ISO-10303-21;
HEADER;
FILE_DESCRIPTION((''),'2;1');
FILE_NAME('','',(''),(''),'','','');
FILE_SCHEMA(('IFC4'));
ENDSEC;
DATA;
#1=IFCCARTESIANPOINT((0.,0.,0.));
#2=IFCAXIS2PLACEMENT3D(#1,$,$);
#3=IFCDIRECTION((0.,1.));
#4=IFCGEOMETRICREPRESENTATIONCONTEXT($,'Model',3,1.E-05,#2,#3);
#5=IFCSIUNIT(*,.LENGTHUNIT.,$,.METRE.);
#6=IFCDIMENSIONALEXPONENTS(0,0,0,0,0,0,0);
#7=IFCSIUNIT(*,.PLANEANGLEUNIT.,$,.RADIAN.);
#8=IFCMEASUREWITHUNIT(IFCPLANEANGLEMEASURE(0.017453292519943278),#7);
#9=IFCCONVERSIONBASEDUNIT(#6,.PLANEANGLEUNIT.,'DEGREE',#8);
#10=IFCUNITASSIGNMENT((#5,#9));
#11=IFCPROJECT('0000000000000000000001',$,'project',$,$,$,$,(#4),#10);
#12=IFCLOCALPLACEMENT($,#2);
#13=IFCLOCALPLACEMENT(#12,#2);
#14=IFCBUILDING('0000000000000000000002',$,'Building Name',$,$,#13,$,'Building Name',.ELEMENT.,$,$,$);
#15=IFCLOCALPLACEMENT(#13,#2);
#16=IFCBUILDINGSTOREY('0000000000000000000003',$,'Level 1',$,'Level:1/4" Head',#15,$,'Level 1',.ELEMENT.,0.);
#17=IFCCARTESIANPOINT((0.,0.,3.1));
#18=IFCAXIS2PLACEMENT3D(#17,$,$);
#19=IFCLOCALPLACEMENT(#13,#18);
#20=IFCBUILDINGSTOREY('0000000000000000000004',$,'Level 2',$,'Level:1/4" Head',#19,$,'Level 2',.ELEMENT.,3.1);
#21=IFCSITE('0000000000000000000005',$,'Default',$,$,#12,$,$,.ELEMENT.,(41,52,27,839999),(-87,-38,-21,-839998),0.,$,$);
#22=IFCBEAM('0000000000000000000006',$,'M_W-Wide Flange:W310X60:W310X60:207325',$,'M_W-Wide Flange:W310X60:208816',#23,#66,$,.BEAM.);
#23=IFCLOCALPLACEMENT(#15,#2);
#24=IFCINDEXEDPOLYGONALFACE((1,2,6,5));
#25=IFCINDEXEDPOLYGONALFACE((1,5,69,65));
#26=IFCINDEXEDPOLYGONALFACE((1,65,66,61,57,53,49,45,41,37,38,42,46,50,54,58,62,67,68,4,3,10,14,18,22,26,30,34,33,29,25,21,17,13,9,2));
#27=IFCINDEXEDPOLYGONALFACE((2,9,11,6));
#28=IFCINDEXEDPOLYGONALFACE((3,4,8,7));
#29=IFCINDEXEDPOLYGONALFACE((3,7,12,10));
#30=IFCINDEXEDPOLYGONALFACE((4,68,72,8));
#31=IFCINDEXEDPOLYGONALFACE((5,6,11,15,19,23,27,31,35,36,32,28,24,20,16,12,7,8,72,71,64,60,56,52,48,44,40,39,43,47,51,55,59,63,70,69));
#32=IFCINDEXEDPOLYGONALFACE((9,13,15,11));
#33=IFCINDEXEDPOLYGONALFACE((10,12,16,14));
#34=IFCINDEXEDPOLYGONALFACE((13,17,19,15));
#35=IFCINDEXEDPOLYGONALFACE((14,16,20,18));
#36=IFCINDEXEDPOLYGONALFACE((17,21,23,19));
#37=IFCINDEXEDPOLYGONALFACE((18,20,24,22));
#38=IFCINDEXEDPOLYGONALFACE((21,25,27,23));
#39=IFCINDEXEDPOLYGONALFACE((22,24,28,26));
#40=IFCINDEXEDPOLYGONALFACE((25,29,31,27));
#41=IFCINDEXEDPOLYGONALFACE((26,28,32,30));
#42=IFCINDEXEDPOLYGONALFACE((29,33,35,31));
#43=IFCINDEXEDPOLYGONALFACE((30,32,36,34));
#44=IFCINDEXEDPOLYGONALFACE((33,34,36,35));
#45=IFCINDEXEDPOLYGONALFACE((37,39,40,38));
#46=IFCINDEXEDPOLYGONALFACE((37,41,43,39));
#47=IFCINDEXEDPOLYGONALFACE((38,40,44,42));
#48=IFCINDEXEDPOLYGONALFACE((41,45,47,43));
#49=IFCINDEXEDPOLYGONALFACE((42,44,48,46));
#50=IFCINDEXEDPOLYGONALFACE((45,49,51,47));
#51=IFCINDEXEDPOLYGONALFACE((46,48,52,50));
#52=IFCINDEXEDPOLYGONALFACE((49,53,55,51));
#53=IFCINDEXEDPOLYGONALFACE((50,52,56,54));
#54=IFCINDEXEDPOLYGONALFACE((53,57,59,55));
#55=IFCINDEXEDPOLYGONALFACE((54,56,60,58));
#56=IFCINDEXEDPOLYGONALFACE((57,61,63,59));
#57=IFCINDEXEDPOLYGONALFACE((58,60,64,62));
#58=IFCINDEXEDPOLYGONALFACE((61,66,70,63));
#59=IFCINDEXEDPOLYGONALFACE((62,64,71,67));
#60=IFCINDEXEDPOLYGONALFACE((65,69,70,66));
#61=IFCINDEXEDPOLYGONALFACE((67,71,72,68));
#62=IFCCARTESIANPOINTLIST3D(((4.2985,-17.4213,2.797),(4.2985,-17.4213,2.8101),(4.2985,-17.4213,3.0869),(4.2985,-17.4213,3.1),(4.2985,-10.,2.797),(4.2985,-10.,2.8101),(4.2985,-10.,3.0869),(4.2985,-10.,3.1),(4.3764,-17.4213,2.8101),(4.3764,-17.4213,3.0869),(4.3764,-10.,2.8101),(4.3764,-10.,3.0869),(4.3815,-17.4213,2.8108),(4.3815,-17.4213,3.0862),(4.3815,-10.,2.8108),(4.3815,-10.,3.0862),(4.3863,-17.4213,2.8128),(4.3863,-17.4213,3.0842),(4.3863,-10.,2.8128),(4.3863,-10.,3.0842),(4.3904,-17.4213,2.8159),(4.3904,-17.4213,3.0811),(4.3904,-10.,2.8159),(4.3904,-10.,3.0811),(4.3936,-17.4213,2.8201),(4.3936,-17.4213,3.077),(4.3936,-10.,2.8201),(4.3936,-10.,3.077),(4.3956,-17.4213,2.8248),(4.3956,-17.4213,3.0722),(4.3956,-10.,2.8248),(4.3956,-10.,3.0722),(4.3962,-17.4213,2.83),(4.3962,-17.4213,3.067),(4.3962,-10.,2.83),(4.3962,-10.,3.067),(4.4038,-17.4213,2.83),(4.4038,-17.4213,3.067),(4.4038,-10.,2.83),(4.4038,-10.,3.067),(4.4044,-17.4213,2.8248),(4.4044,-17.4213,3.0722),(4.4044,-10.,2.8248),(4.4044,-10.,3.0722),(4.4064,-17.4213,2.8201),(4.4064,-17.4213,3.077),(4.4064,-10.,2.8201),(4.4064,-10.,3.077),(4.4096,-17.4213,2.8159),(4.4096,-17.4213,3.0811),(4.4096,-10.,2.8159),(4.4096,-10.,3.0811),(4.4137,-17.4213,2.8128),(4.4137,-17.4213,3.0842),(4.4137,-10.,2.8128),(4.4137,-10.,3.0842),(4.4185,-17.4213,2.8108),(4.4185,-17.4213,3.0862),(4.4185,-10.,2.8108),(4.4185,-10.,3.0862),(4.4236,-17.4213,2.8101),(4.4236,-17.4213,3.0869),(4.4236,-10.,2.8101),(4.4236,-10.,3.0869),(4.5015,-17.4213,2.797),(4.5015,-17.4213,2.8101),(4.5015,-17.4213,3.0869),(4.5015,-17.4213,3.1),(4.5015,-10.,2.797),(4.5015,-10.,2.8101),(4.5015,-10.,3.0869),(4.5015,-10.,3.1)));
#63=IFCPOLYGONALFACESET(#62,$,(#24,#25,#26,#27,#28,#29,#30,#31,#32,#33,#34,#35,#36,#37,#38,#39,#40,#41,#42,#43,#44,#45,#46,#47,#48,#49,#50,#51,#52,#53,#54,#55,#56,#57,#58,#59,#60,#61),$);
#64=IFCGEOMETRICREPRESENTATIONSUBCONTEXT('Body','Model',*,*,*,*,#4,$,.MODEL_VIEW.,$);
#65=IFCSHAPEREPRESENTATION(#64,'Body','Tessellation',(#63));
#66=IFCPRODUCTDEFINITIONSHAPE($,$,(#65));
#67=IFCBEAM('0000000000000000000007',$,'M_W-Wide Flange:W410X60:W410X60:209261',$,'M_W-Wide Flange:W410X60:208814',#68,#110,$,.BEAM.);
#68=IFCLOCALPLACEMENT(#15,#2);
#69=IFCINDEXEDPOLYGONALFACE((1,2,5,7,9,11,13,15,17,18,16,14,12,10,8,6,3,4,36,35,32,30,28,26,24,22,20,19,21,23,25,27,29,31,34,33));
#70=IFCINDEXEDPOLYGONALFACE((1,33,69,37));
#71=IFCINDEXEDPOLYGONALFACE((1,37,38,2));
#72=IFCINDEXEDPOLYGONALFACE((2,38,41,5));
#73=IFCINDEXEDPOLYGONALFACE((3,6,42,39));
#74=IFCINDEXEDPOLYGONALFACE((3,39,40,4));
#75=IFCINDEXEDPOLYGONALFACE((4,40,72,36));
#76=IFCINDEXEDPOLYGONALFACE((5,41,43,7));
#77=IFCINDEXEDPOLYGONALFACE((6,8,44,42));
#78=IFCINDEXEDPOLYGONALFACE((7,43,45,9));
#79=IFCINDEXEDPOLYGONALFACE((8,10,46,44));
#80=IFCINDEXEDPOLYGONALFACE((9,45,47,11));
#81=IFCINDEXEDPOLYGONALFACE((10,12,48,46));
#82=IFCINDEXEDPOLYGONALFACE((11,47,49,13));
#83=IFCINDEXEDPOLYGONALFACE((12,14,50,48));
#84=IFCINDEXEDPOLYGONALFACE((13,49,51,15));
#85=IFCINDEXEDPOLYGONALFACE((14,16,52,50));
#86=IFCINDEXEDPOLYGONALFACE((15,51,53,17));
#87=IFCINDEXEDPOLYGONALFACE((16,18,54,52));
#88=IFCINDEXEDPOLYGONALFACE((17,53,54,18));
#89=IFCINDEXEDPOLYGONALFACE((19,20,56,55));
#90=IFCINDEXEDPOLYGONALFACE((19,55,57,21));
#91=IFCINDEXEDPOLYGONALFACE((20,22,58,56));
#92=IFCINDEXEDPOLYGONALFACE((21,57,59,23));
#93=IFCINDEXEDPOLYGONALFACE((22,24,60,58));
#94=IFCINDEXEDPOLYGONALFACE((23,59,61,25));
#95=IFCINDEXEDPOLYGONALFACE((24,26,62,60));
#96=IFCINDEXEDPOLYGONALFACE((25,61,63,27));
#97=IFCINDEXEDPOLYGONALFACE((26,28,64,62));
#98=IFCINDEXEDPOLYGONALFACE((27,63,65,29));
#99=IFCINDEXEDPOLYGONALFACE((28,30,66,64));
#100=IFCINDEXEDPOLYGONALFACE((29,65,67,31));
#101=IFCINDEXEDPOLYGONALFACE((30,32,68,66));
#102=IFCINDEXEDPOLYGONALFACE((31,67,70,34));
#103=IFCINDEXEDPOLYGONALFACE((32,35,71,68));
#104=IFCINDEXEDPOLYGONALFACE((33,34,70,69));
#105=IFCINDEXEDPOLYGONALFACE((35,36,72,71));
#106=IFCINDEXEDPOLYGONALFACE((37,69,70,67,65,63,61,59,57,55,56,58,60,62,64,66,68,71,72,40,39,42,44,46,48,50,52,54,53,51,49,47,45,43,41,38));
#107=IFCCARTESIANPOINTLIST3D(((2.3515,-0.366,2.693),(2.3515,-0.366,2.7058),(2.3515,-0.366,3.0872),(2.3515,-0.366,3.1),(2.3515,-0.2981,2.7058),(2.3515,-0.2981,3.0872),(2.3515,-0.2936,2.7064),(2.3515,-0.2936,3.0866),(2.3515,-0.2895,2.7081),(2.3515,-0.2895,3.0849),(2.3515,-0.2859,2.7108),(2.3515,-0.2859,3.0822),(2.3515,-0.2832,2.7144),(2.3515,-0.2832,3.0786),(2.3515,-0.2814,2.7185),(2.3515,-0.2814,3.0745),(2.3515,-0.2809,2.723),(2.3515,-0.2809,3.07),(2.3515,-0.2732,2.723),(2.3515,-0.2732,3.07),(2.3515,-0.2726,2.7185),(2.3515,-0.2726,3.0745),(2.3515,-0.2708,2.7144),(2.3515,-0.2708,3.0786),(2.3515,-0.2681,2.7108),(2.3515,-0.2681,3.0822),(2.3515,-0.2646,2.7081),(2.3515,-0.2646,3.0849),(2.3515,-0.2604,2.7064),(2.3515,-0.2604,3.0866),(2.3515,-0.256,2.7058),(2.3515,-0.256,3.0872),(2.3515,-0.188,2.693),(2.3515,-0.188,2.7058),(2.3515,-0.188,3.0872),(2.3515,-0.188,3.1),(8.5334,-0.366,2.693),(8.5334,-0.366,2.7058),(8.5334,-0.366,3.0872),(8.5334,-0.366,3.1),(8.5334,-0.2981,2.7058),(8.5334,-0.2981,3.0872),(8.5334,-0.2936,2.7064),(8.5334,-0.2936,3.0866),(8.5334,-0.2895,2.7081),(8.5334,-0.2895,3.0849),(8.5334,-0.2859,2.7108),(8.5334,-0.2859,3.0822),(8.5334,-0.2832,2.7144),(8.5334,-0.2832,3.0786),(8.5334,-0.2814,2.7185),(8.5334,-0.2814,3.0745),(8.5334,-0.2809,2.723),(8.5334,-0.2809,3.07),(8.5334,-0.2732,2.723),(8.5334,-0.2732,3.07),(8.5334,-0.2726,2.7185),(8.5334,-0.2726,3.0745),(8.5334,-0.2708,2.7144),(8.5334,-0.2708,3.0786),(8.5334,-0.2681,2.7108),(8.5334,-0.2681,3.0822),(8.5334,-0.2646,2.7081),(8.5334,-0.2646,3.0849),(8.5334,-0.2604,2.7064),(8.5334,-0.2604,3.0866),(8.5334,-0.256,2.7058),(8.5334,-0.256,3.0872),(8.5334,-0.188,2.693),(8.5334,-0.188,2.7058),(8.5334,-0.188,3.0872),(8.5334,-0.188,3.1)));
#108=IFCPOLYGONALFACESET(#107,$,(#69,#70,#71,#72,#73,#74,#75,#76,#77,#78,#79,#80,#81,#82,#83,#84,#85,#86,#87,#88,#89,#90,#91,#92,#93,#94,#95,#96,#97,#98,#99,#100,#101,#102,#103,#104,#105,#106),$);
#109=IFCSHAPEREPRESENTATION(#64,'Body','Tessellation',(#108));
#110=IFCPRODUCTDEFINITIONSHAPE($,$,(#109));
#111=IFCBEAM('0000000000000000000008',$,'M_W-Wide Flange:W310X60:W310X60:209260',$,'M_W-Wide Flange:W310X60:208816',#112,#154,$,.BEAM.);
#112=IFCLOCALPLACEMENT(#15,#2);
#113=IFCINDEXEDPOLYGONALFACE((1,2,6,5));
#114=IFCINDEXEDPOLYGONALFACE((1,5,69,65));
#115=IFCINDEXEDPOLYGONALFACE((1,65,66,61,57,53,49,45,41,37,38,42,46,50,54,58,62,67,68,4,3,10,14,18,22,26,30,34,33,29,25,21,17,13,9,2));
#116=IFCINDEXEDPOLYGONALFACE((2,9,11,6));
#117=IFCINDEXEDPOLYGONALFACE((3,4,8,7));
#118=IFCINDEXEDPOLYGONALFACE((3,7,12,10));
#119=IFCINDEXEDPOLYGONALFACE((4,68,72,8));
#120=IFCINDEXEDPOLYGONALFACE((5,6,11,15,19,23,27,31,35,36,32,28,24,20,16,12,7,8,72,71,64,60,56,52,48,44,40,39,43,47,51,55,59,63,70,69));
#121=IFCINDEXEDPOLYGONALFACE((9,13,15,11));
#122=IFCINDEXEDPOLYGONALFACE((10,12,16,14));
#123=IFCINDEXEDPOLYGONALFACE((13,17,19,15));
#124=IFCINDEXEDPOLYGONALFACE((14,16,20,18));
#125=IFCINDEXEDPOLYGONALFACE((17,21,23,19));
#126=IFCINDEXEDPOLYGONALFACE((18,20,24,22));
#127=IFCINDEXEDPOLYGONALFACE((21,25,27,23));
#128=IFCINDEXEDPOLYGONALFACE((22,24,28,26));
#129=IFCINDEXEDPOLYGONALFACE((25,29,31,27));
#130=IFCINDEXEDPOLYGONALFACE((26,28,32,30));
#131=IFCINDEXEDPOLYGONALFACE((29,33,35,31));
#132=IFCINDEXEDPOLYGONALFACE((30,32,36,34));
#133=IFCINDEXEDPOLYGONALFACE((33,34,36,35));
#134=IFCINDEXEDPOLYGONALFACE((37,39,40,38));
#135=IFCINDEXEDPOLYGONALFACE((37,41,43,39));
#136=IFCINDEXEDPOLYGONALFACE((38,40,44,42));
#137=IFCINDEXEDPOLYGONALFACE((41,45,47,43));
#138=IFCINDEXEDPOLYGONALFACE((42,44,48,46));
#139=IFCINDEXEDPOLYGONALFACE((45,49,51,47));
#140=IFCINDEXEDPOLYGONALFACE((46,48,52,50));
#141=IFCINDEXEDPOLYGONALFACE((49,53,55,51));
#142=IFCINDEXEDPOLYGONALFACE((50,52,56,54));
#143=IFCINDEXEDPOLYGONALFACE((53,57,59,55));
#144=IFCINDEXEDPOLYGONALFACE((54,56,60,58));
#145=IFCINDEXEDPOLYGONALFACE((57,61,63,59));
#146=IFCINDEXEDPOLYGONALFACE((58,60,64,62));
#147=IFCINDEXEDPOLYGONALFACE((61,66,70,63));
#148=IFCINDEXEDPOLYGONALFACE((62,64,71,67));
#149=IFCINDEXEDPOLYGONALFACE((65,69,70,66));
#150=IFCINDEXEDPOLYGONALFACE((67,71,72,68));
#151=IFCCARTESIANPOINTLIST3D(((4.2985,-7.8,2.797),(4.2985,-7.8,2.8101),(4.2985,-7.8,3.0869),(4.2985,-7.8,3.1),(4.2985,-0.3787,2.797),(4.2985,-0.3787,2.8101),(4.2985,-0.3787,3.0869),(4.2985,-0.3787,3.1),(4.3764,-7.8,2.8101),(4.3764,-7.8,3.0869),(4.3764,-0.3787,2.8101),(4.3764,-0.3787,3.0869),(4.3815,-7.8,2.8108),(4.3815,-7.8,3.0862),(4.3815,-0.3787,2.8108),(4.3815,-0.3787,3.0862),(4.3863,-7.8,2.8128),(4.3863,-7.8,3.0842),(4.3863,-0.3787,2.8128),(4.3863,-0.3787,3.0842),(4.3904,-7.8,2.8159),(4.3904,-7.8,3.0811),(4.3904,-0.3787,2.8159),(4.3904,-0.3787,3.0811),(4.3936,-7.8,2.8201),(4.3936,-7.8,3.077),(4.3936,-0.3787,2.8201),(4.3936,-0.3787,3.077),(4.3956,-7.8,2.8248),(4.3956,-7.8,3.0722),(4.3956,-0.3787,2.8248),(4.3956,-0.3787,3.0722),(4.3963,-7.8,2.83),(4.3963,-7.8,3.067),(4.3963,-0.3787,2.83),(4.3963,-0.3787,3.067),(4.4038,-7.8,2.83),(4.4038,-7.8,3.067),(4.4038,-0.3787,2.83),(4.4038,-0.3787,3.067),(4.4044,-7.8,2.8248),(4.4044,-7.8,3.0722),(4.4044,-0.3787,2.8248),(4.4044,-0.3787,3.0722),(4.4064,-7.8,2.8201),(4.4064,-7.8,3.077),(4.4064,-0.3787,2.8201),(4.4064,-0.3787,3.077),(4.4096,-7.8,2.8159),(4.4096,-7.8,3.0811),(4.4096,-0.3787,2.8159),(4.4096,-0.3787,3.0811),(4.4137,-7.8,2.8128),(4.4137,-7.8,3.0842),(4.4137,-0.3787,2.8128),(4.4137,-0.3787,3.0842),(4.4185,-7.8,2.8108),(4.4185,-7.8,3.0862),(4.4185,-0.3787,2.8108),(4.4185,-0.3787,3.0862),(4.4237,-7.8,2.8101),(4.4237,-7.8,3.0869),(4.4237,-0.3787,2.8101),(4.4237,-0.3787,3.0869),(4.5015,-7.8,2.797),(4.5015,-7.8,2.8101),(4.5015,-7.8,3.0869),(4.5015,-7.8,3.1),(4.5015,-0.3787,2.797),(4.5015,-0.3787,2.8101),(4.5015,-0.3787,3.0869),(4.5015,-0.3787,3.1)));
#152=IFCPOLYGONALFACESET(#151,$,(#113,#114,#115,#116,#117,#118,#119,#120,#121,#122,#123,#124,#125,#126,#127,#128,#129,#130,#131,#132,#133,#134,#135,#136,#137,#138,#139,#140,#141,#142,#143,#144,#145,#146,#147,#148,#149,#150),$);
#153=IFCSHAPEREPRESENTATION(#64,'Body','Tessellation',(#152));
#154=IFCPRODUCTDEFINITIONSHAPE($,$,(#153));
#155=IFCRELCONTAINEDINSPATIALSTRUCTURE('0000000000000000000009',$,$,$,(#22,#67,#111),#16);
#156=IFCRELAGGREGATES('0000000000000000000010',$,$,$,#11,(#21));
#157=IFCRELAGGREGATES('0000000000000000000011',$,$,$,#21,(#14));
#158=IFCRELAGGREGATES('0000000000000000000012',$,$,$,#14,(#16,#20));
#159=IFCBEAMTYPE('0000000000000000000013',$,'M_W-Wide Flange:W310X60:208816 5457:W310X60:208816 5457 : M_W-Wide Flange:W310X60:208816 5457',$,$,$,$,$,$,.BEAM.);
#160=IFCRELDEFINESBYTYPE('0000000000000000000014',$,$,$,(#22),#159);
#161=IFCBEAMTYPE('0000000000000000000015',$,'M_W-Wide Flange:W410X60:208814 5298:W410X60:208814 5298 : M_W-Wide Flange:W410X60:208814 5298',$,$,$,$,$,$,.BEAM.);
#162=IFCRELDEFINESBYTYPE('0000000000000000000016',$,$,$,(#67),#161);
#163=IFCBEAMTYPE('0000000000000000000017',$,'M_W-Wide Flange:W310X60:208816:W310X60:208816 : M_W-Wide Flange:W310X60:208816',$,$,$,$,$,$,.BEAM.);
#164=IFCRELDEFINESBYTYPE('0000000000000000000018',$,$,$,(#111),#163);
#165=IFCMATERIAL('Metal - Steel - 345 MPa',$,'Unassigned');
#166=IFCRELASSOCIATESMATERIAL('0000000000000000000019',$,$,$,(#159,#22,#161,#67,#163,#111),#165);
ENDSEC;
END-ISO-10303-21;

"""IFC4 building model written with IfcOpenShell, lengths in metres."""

from ifc_helpers import new_model, entity, si_unit, converted_unit, direction, frame, origin, place, context, subcontext, project, spatial, line, arc, indexed_curve, outline, extrude, source, transform, mapped, material, type_object, type_shapes, element, save


model = new_model("IFC4")

# Units and contexts
model_context = context("Model", 3, precision=1e-05, world=origin(), true_north=direction((0.0, 1.0)))
body_context = subcontext(model_context, "Body", "Model", "MODEL_VIEW")
ifc_project = project(units=[si_unit("LENGTHUNIT", "METRE"), converted_unit("PLANEANGLEUNIT", "DEGREE", entity("IfcPlaneAngleMeasure", 0.017453292519943278), si_unit("PLANEANGLEUNIT", "RADIAN"), dimensions=[0, 0, 0, 0, 0, 0, 0])], contexts=[model_context])

# Site, building, storey
site_placement = place(None, origin())
site = spatial("IfcSite", under=ifc_project, at=site_placement, Name="Default", CompositionType="ELEMENT", RefLatitude=(41, 52, 27, 839999), RefLongitude=(-87, -38, -21, -839998), RefElevation=0.0)
building_placement = place(site_placement, origin())
building = spatial("IfcBuilding", under=site, at=building_placement, Name="Building Name", LongName="Building Name", CompositionType="ELEMENT")
storey_1_placement = place(building_placement, origin())
storey_1 = spatial("IfcBuildingStorey", under=building, at=storey_1_placement, Name="Level 1", ObjectType="Level:1/4\" Head", LongName="Level 1", CompositionType="ELEMENT", Elevation=0.0)

# Beams
ifc_material_1 = material(Name="Metal - Steel - 345 MPa", Category="Unassigned")
beam_type_1 = type_object("IfcBeamType", Name="M_W-Wide Flange:W310X60:208816 5457:W310X60:208816 5457 : M_W-Wide Flange:W310X60:208816 5457", PredefinedType="BEAM", material=ifc_material_1)
shared_shape_1 = source(origin(), body_context, "Body", "SweptSolid", [
    extrude(outline(indexed_curve([(-0.1515, -0.1015), (-0.1384, -0.1015), (-0.1384, -0.0237), (-0.1326, -0.0096), (-0.1185, -0.0038), (0.1185, -0.0038), (0.1326, -0.0096), (0.1384, -0.0237), (0.1384, -0.1015), (0.1515, -0.1015), (0.1515, 0.1015), (0.1384, 0.1015), (0.1384, 0.0236), (0.1326, 0.0096), (0.1185, 0.0038), (-0.1185, 0.0038), (-0.1326, 0.0096), (-0.1384, 0.0236), (-0.1384, 0.1015), (-0.1515, 0.1015)], segments=[line(1, 2, 3), arc(3, 4, 5), line(5, 6), arc(6, 7, 8), line(8, 9, 10, 11, 12, 13), arc(13, 14, 15), line(15, 16), arc(16, 17, 18), line(18, 19, 20, 1)], self_intersect=False)), frame((0.0, 0.0, -0.1515), z_axis=(0.0, 1.0, 0.0), x_axis=(0.0, 0.0, 1.0)), (0.0, 0.0, 1.0), 7.4213),
])
type_shapes(beam_type_1, [shared_shape_1])
beam_1_placement = place(storey_1_placement, frame((4.4, -10.0, 3.1), z_axis=(0.0, 0.0, 1.0), x_axis=(-1.0, 0.0, 0.0)))
element("IfcBeam", 1, at=beam_1_placement, inside=storey_1, type_object=beam_type_1, material=ifc_material_1, Name="M_W-Wide Flange:W310X60:W310X60:207325", ObjectType="M_W-Wide Flange:W310X60:208816", PredefinedType="BEAM", context=body_context, shape_type="MappedRepresentation", body=[
    mapped(shared_shape_1, transform((0.0, 0.0, 0.0), scale=1.0)),
])
beam_type_2 = type_object("IfcBeamType", Name="M_W-Wide Flange:W410X60:208814 5298:W410X60:208814 5298 : M_W-Wide Flange:W410X60:208814 5298", PredefinedType="BEAM", material=ifc_material_1)
shared_shape_2 = source(origin(), body_context, "Body", "SweptSolid", [
    extrude(outline(indexed_curve([(-0.2035, -0.089), (-0.1907, -0.089), (-0.1907, -0.0211), (-0.1857, -0.0089), (-0.1735, -0.0039), (0.1735, -0.0039), (0.1857, -0.0089), (0.1907, -0.0211), (0.1907, -0.089), (0.2035, -0.089), (0.2035, 0.089), (0.1907, 0.089), (0.1907, 0.0211), (0.1857, 0.0089), (0.1735, 0.0038), (-0.1735, 0.0038), (-0.1857, 0.0089), (-0.1907, 0.021), (-0.1907, 0.089), (-0.2035, 0.089)], segments=[line(1, 2, 3), arc(3, 4, 5), line(5, 6), arc(6, 7, 8), line(8, 9, 10, 11, 12, 13), arc(13, 14, 15), line(15, 16), arc(16, 17, 18), line(18, 19, 20, 1)], self_intersect=False)), frame((0.0, 0.0581, -0.2035), z_axis=(0.0, 1.0, 0.0), x_axis=(0.0, 0.0, 1.0)), (0.0, 0.0, 1.0), 6.1819),
])
type_shapes(beam_type_2, [shared_shape_2])
beam_2_placement = place(storey_1_placement, frame((8.5915, -0.277, 3.1), z_axis=(0.0, 0.0, 1.0), x_axis=(0.0, 1.0, 0.0)))
element("IfcBeam", 2, at=beam_2_placement, inside=storey_1, type_object=beam_type_2, material=ifc_material_1, Name="M_W-Wide Flange:W410X60:W410X60:209261", ObjectType="M_W-Wide Flange:W410X60:208814", PredefinedType="BEAM", context=body_context, shape_type="MappedRepresentation", body=[
    mapped(shared_shape_2, transform((0.0, 0.0, 0.0), scale=1.0)),
])
beam_type_3 = type_object("IfcBeamType", Name="M_W-Wide Flange:W310X60:208816:W310X60:208816 : M_W-Wide Flange:W310X60:208816", PredefinedType="BEAM", material=ifc_material_1)
shared_shape_3 = source(origin(), body_context, "Body", "SweptSolid", [
    extrude(outline(indexed_curve([(-0.0237, -0.1384), (-0.1015, -0.1384), (-0.1015, -0.1515), (0.1015, -0.1515), (0.1015, -0.1384), (0.0236, -0.1384), (0.0096, -0.1326), (0.0038, -0.1185), (0.0037, 0.1185), (0.0096, 0.1326), (0.0236, 0.1384), (0.1015, 0.1384), (0.1015, 0.1515), (-0.1015, 0.1515), (-0.1015, 0.1384), (-0.0236, 0.1384), (-0.0096, 0.1326), (-0.0038, 0.1185), (-0.0038, -0.1185), (-0.0096, -0.1326)], segments=[line(1, 2, 3, 4, 5, 6), arc(6, 7, 8), line(8, 9), arc(9, 10, 11), line(11, 12, 13, 14, 15, 16), arc(16, 17, 18), line(18, 19), arc(19, 20, 1)], self_intersect=False)), frame((0.0, 0.0, -0.1515), z_axis=(0.0, -1.0, 0.0), x_axis=(1.0, 0.0, 0.0)), (0.0, 0.0, -1.0), 7.4213),
])
type_shapes(beam_type_3, [shared_shape_3])
beam_3_placement = place(storey_1_placement, frame((4.4, -7.8, 3.1)))
element("IfcBeam", 3, at=beam_3_placement, inside=storey_1, type_object=beam_type_3, material=ifc_material_1, Name="M_W-Wide Flange:W310X60:W310X60:209260", ObjectType="M_W-Wide Flange:W310X60:208816", PredefinedType="BEAM", context=body_context, shape_type="MappedRepresentation", body=[
    mapped(shared_shape_3, transform((0.0, 0.0, 0.0), scale=1.0)),
])

# Shared definitions
storey_2_placement = place(building_placement, frame((0.0, 0.0, 3.1)))
storey_2 = spatial("IfcBuildingStorey", under=building, at=storey_2_placement, Name="Level 2", ObjectType="Level:1/4\" Head", LongName="Level 2", CompositionType="ELEMENT", Elevation=3.1)

save(model, "model.ifc")
